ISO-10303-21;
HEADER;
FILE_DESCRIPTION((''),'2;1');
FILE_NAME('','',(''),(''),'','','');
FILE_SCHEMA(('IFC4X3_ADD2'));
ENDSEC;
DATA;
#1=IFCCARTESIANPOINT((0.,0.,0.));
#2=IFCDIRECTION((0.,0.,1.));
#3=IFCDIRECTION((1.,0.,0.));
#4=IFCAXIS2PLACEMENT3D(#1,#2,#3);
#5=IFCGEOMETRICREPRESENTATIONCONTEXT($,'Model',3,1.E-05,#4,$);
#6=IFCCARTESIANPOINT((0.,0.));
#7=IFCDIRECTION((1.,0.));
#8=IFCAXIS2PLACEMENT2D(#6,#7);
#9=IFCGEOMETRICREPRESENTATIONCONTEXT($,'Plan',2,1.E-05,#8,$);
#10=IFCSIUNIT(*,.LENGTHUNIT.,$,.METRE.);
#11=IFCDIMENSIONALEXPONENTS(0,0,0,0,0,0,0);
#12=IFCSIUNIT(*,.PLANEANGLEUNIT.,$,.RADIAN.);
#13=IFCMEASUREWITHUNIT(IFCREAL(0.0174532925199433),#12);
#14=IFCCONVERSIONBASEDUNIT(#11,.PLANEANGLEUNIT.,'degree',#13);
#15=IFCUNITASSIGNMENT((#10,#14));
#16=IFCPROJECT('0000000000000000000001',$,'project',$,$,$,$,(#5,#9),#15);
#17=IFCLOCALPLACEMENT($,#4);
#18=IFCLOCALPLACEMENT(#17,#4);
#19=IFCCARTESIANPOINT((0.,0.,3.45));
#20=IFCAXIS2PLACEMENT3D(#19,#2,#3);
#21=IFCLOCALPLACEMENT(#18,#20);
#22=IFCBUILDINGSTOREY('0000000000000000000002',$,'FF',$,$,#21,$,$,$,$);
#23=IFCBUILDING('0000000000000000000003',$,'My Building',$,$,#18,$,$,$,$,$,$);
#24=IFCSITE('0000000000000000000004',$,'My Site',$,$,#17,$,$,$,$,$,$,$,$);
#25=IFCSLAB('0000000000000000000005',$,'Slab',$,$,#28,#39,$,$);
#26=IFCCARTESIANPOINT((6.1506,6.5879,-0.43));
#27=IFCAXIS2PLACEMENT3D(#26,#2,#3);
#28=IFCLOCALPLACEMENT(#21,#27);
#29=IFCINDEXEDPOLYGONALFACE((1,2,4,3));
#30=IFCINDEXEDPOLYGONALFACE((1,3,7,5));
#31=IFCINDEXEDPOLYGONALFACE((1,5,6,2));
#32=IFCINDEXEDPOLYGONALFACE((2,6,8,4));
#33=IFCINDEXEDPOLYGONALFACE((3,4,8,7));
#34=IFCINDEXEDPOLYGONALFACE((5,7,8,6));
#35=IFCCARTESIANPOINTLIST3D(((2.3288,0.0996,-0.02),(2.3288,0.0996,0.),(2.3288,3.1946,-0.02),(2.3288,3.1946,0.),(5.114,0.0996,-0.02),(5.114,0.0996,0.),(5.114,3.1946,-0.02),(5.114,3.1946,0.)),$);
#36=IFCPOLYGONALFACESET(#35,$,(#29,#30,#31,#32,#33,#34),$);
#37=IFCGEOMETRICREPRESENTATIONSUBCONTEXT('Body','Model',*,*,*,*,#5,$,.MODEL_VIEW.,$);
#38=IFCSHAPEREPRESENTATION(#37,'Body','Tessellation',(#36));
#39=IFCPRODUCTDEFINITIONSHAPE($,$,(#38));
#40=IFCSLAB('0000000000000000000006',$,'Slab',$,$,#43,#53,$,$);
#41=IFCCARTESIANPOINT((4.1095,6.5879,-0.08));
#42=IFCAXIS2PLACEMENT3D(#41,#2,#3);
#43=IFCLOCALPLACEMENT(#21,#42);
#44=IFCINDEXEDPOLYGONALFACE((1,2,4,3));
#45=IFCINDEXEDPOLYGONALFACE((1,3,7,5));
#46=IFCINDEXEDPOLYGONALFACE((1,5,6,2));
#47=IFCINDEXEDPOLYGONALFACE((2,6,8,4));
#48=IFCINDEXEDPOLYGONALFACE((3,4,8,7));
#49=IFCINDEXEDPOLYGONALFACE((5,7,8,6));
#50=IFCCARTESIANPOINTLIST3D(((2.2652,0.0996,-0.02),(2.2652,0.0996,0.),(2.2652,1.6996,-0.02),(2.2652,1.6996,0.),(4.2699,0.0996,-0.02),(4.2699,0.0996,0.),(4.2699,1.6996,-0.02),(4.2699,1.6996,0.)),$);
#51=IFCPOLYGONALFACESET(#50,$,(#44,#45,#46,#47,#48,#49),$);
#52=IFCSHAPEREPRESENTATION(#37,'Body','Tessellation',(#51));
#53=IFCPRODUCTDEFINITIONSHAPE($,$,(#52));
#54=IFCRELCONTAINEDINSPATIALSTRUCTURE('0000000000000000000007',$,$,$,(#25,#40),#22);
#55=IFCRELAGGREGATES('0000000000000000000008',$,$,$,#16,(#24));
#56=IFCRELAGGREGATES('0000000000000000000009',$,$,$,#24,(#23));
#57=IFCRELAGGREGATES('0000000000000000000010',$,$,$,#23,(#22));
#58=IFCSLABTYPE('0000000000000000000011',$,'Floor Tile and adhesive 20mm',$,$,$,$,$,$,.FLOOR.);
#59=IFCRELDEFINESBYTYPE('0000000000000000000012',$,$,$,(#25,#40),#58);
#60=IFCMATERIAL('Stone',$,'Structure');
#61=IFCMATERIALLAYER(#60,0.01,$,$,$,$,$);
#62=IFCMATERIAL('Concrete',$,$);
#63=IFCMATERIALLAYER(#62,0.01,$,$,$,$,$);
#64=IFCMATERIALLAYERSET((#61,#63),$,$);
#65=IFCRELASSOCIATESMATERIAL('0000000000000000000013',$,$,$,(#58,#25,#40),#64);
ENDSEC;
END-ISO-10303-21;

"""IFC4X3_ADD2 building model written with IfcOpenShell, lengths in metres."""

from ifc_helpers import new_model, entity, si_unit, converted_unit, frame, origin_with_axes, origin_2d_with_axis, place, context, subcontext, project, spatial, indexed_curve, outline, extrude, material, layer, layer_set, layer_usage, type_object, element, save


model = new_model("IFC4X3_ADD2")

# Units and contexts
model_context = context("Model", 3, precision=1e-05, world=origin_with_axes())
plan_context = context("Plan", 2, precision=1e-05, world=origin_2d_with_axis())
body_context = subcontext(model_context, "Body", "Model", "MODEL_VIEW")
ifc_project = project(units=[si_unit("LENGTHUNIT", "METRE"), converted_unit("PLANEANGLEUNIT", "degree", entity("IfcReal", 0.0174532925199433), si_unit("PLANEANGLEUNIT", "RADIAN"), dimensions=[0, 0, 0, 0, 0, 0, 0])], contexts=[model_context, plan_context])

# Site, building, storey
site_placement = place(None, origin_with_axes())
site = spatial("IfcSite", under=ifc_project, at=site_placement, Name="My Site")
building_placement = place(site_placement, origin_with_axes())
building = spatial("IfcBuilding", under=site, at=building_placement, Name="My Building")
storey_placement = place(building_placement, frame((0.0, 0.0, 3.45), z_axis=(0.0, 0.0, 1.0), x_axis=(1.0, 0.0, 0.0)))
storey = spatial("IfcBuildingStorey", under=building, at=storey_placement, Name="FF")

# Slabs
ifc_material_1 = material(Name="Stone", Category="Structure")
ifc_layer_1 = layer(ifc_material_1, 0.01)
ifc_material_2 = material(Name="Concrete")
ifc_layer_2 = layer(ifc_material_2, 0.01)
ifc_layer_set_1 = layer_set([ifc_layer_1, ifc_layer_2])
slab_type = type_object("IfcSlabType", Name="Floor Tile and adhesive 20mm", PredefinedType="FLOOR", material=ifc_layer_set_1)
ifc_layer_usage_1 = layer_usage(ifc_layer_set_1, "AXIS3", "POSITIVE", -0.02)
slab_1_placement = place(storey_placement, frame((6.1506, 6.5879, -0.43), z_axis=(0.0, 0.0, 1.0), x_axis=(1.0, 0.0, 0.0)))
element("IfcSlab", 1, at=slab_1_placement, inside=storey, type_object=slab_type, material=ifc_layer_usage_1, Name="Slab", context=body_context, shape_type="SweptSolid", body=[
    extrude(outline(indexed_curve([(2.3288, 0.0996), (2.3288, 3.1946), (5.114, 3.1946), (5.114, 0.0996), (2.3288, 0.0996)])), frame((0.0, 0.0, -0.02), z_axis=(0.0, 0.0, 1.0), x_axis=(1.0, 0.0, 0.0)), (0.0, 0.0, 1.0), 0.02),
])
ifc_layer_usage_2 = layer_usage(ifc_layer_set_1, "AXIS3", "POSITIVE", -0.02)
slab_2_placement = place(storey_placement, frame((4.1095, 6.5879, -0.08), z_axis=(0.0, 0.0, 1.0), x_axis=(1.0, 0.0, 0.0)))
element("IfcSlab", 2, at=slab_2_placement, inside=storey, type_object=slab_type, material=ifc_layer_usage_2, Name="Slab", context=body_context, shape_type="SweptSolid", body=[
    extrude(outline(indexed_curve([(4.2699, 0.0996), (4.2699, 1.6996), (2.2652, 1.6996), (2.2652, 0.0996), (4.2699, 0.0996)])), frame((0.0, 0.0, -0.02), z_axis=(0.0, 0.0, 1.0), x_axis=(1.0, 0.0, 0.0)), (0.0, 0.0, 1.0), 0.02),
])

save(model, "model.ifc")
